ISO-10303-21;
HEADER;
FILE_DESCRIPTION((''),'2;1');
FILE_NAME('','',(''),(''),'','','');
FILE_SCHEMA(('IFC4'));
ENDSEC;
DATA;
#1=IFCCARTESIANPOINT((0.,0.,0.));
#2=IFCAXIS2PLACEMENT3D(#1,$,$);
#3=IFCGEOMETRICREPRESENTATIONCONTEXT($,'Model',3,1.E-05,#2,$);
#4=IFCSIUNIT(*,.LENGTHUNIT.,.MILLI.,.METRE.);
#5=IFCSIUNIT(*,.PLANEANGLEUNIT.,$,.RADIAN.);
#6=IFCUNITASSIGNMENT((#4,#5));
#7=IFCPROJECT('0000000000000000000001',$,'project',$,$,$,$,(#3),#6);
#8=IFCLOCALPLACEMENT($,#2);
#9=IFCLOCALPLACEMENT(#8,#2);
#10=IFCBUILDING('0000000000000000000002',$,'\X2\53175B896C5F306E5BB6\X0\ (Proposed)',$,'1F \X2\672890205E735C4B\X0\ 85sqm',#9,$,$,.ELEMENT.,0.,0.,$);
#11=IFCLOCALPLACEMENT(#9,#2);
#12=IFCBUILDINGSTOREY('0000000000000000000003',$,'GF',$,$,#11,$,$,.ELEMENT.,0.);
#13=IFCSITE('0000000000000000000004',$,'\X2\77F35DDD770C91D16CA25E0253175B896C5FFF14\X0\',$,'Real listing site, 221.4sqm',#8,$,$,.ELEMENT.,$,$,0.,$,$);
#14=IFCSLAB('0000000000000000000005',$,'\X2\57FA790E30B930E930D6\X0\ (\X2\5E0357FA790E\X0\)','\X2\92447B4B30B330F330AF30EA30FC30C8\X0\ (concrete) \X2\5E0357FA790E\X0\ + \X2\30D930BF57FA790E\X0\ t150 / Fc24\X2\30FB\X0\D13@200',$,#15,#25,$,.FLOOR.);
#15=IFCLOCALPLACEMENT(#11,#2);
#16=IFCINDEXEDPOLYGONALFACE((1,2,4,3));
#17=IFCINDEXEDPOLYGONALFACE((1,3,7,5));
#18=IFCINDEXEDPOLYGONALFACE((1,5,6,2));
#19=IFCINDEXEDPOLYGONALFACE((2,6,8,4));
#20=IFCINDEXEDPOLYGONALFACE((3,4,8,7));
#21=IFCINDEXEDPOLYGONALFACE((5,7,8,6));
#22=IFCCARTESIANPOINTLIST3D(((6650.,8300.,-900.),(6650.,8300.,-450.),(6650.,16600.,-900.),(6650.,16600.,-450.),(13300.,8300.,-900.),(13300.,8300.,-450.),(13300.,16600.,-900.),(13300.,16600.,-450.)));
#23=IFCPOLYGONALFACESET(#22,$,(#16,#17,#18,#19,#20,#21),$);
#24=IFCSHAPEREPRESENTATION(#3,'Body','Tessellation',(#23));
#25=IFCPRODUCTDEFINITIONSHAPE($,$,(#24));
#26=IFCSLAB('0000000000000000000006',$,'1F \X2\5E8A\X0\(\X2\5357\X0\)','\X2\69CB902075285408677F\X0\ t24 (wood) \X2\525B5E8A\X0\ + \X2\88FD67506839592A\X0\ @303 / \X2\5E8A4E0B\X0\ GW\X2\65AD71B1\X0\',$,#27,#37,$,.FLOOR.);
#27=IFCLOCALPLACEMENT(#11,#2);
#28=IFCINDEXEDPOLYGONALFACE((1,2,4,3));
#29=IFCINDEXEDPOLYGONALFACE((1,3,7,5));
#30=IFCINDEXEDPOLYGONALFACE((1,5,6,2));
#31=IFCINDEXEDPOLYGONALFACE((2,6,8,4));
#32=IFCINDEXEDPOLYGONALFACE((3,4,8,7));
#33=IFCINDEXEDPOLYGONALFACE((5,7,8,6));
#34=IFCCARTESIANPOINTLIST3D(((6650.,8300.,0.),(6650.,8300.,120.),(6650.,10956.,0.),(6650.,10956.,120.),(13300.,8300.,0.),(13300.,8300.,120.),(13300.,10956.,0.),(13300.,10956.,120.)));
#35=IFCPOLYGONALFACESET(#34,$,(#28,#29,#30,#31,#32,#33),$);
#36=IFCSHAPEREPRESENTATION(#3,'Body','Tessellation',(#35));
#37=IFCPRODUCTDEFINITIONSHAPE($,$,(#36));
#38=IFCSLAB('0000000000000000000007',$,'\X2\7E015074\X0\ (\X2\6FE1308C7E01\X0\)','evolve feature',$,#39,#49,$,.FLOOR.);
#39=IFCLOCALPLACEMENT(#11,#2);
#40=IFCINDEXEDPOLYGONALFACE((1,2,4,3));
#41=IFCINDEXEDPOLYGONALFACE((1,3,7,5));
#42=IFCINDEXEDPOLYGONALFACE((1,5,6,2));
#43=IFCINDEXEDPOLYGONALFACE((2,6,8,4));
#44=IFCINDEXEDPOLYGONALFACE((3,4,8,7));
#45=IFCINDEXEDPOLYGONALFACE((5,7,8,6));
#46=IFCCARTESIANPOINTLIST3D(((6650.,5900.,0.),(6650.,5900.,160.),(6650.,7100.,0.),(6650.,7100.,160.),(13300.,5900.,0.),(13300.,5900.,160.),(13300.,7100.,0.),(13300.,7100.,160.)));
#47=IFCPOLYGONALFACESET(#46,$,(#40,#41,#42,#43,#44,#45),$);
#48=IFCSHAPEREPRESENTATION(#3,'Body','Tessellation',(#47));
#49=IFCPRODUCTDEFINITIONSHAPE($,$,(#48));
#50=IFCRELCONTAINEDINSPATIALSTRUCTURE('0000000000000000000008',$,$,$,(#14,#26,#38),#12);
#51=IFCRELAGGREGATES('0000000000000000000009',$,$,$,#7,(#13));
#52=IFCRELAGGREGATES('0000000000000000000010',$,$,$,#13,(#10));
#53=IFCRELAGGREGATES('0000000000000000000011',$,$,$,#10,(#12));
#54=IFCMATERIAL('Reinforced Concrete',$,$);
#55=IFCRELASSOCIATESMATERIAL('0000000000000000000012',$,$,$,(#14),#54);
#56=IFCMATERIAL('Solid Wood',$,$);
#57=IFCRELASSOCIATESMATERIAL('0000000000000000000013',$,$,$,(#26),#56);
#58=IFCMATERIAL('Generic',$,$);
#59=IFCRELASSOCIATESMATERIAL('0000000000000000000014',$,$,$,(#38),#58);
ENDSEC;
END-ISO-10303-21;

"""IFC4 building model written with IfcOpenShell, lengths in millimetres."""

from ifc_helpers import new_model, si_unit, frame, frame_2d, origin, place, context, project, spatial, rectangle, extrude, material, element, save


model = new_model("IFC4")

# Units and contexts
model_context = context("Model", 3, precision=1e-05, world=origin())
ifc_project = project(units=[si_unit("LENGTHUNIT", "METRE", prefix="MILLI"), si_unit("PLANEANGLEUNIT", "RADIAN")], contexts=[model_context])

# Site, building, storey
site_placement = place(None, origin())
site = spatial("IfcSite", under=ifc_project, at=site_placement, Name="石川県金沢市北安江４", ObjectType="Real listing site, 221.4sqm", CompositionType="ELEMENT", RefElevation=0.0)
building_placement = place(site_placement, origin())
building = spatial("IfcBuilding", under=site, at=building_placement, Name="北安江の家 (Proposed)", ObjectType="1F 木造平屋 85sqm", CompositionType="ELEMENT", ElevationOfRefHeight=0.0, ElevationOfTerrain=0.0)
storey_placement = place(building_placement, origin())
storey = spatial("IfcBuildingStorey", under=building, at=storey_placement, Name="GF", CompositionType="ELEMENT", Elevation=0.0)

# Slabs
ifc_material_1 = material(Name="Reinforced Concrete")
slab_1_placement = place(storey_placement, frame((3325.0, 4150.0, -450.0)))
element("IfcSlab", 1, at=slab_1_placement, inside=storey, material=ifc_material_1, Name="基礎スラブ (布基礎)", Description="鉄筋コンクリート (concrete) 布基礎 + ベタ基礎 t150 / Fc24・D13@200", PredefinedType="FLOOR", context=model_context, shape_type="SweptSolid", body=[
    extrude(rectangle(XDim=6650.0, YDim=8300.0, at=frame_2d((3325.0, 4150.0))), frame((3325.0, 4150.0, -450.0)), (0.0, 0.0, 1.0), 450.0),
])
ifc_material_2 = material(Name="Solid Wood")
slab_2_placement = place(storey_placement, frame((3325.0, 4150.0, 0.0)))
element("IfcSlab", 2, at=slab_2_placement, inside=storey, material=ifc_material_2, Name="1F 床(南)", Description="構造用合板 t24 (wood) 剛床 + 製材根太 @303 / 床下 GW断熱", PredefinedType="FLOOR", context=model_context, shape_type="SweptSolid", body=[
    extrude(rectangle(XDim=6650.0, YDim=2656.0, at=frame_2d((3325.0, 1328.0))), frame((3325.0, 4150.0, 0.0)), (0.0, 0.0, 1.0), 120.0),
])
ifc_material_3 = material(Name="Generic")
slab_3_placement = place(storey_placement, frame((3325.0, 2950.0, 0.0)))
element("IfcSlab", 3, at=slab_3_placement, inside=storey, material=ifc_material_3, Name="縁側 (濡れ縁)", Description="evolve feature", PredefinedType="FLOOR", context=model_context, shape_type="SweptSolid", body=[
    extrude(rectangle(XDim=6650.0, YDim=1200.0, at=frame_2d((3325.0, 600.0))), frame((3325.0, 2950.0, 0.0)), (0.0, 0.0, 1.0), 160.0),
])

save(model, "model.ifc")
